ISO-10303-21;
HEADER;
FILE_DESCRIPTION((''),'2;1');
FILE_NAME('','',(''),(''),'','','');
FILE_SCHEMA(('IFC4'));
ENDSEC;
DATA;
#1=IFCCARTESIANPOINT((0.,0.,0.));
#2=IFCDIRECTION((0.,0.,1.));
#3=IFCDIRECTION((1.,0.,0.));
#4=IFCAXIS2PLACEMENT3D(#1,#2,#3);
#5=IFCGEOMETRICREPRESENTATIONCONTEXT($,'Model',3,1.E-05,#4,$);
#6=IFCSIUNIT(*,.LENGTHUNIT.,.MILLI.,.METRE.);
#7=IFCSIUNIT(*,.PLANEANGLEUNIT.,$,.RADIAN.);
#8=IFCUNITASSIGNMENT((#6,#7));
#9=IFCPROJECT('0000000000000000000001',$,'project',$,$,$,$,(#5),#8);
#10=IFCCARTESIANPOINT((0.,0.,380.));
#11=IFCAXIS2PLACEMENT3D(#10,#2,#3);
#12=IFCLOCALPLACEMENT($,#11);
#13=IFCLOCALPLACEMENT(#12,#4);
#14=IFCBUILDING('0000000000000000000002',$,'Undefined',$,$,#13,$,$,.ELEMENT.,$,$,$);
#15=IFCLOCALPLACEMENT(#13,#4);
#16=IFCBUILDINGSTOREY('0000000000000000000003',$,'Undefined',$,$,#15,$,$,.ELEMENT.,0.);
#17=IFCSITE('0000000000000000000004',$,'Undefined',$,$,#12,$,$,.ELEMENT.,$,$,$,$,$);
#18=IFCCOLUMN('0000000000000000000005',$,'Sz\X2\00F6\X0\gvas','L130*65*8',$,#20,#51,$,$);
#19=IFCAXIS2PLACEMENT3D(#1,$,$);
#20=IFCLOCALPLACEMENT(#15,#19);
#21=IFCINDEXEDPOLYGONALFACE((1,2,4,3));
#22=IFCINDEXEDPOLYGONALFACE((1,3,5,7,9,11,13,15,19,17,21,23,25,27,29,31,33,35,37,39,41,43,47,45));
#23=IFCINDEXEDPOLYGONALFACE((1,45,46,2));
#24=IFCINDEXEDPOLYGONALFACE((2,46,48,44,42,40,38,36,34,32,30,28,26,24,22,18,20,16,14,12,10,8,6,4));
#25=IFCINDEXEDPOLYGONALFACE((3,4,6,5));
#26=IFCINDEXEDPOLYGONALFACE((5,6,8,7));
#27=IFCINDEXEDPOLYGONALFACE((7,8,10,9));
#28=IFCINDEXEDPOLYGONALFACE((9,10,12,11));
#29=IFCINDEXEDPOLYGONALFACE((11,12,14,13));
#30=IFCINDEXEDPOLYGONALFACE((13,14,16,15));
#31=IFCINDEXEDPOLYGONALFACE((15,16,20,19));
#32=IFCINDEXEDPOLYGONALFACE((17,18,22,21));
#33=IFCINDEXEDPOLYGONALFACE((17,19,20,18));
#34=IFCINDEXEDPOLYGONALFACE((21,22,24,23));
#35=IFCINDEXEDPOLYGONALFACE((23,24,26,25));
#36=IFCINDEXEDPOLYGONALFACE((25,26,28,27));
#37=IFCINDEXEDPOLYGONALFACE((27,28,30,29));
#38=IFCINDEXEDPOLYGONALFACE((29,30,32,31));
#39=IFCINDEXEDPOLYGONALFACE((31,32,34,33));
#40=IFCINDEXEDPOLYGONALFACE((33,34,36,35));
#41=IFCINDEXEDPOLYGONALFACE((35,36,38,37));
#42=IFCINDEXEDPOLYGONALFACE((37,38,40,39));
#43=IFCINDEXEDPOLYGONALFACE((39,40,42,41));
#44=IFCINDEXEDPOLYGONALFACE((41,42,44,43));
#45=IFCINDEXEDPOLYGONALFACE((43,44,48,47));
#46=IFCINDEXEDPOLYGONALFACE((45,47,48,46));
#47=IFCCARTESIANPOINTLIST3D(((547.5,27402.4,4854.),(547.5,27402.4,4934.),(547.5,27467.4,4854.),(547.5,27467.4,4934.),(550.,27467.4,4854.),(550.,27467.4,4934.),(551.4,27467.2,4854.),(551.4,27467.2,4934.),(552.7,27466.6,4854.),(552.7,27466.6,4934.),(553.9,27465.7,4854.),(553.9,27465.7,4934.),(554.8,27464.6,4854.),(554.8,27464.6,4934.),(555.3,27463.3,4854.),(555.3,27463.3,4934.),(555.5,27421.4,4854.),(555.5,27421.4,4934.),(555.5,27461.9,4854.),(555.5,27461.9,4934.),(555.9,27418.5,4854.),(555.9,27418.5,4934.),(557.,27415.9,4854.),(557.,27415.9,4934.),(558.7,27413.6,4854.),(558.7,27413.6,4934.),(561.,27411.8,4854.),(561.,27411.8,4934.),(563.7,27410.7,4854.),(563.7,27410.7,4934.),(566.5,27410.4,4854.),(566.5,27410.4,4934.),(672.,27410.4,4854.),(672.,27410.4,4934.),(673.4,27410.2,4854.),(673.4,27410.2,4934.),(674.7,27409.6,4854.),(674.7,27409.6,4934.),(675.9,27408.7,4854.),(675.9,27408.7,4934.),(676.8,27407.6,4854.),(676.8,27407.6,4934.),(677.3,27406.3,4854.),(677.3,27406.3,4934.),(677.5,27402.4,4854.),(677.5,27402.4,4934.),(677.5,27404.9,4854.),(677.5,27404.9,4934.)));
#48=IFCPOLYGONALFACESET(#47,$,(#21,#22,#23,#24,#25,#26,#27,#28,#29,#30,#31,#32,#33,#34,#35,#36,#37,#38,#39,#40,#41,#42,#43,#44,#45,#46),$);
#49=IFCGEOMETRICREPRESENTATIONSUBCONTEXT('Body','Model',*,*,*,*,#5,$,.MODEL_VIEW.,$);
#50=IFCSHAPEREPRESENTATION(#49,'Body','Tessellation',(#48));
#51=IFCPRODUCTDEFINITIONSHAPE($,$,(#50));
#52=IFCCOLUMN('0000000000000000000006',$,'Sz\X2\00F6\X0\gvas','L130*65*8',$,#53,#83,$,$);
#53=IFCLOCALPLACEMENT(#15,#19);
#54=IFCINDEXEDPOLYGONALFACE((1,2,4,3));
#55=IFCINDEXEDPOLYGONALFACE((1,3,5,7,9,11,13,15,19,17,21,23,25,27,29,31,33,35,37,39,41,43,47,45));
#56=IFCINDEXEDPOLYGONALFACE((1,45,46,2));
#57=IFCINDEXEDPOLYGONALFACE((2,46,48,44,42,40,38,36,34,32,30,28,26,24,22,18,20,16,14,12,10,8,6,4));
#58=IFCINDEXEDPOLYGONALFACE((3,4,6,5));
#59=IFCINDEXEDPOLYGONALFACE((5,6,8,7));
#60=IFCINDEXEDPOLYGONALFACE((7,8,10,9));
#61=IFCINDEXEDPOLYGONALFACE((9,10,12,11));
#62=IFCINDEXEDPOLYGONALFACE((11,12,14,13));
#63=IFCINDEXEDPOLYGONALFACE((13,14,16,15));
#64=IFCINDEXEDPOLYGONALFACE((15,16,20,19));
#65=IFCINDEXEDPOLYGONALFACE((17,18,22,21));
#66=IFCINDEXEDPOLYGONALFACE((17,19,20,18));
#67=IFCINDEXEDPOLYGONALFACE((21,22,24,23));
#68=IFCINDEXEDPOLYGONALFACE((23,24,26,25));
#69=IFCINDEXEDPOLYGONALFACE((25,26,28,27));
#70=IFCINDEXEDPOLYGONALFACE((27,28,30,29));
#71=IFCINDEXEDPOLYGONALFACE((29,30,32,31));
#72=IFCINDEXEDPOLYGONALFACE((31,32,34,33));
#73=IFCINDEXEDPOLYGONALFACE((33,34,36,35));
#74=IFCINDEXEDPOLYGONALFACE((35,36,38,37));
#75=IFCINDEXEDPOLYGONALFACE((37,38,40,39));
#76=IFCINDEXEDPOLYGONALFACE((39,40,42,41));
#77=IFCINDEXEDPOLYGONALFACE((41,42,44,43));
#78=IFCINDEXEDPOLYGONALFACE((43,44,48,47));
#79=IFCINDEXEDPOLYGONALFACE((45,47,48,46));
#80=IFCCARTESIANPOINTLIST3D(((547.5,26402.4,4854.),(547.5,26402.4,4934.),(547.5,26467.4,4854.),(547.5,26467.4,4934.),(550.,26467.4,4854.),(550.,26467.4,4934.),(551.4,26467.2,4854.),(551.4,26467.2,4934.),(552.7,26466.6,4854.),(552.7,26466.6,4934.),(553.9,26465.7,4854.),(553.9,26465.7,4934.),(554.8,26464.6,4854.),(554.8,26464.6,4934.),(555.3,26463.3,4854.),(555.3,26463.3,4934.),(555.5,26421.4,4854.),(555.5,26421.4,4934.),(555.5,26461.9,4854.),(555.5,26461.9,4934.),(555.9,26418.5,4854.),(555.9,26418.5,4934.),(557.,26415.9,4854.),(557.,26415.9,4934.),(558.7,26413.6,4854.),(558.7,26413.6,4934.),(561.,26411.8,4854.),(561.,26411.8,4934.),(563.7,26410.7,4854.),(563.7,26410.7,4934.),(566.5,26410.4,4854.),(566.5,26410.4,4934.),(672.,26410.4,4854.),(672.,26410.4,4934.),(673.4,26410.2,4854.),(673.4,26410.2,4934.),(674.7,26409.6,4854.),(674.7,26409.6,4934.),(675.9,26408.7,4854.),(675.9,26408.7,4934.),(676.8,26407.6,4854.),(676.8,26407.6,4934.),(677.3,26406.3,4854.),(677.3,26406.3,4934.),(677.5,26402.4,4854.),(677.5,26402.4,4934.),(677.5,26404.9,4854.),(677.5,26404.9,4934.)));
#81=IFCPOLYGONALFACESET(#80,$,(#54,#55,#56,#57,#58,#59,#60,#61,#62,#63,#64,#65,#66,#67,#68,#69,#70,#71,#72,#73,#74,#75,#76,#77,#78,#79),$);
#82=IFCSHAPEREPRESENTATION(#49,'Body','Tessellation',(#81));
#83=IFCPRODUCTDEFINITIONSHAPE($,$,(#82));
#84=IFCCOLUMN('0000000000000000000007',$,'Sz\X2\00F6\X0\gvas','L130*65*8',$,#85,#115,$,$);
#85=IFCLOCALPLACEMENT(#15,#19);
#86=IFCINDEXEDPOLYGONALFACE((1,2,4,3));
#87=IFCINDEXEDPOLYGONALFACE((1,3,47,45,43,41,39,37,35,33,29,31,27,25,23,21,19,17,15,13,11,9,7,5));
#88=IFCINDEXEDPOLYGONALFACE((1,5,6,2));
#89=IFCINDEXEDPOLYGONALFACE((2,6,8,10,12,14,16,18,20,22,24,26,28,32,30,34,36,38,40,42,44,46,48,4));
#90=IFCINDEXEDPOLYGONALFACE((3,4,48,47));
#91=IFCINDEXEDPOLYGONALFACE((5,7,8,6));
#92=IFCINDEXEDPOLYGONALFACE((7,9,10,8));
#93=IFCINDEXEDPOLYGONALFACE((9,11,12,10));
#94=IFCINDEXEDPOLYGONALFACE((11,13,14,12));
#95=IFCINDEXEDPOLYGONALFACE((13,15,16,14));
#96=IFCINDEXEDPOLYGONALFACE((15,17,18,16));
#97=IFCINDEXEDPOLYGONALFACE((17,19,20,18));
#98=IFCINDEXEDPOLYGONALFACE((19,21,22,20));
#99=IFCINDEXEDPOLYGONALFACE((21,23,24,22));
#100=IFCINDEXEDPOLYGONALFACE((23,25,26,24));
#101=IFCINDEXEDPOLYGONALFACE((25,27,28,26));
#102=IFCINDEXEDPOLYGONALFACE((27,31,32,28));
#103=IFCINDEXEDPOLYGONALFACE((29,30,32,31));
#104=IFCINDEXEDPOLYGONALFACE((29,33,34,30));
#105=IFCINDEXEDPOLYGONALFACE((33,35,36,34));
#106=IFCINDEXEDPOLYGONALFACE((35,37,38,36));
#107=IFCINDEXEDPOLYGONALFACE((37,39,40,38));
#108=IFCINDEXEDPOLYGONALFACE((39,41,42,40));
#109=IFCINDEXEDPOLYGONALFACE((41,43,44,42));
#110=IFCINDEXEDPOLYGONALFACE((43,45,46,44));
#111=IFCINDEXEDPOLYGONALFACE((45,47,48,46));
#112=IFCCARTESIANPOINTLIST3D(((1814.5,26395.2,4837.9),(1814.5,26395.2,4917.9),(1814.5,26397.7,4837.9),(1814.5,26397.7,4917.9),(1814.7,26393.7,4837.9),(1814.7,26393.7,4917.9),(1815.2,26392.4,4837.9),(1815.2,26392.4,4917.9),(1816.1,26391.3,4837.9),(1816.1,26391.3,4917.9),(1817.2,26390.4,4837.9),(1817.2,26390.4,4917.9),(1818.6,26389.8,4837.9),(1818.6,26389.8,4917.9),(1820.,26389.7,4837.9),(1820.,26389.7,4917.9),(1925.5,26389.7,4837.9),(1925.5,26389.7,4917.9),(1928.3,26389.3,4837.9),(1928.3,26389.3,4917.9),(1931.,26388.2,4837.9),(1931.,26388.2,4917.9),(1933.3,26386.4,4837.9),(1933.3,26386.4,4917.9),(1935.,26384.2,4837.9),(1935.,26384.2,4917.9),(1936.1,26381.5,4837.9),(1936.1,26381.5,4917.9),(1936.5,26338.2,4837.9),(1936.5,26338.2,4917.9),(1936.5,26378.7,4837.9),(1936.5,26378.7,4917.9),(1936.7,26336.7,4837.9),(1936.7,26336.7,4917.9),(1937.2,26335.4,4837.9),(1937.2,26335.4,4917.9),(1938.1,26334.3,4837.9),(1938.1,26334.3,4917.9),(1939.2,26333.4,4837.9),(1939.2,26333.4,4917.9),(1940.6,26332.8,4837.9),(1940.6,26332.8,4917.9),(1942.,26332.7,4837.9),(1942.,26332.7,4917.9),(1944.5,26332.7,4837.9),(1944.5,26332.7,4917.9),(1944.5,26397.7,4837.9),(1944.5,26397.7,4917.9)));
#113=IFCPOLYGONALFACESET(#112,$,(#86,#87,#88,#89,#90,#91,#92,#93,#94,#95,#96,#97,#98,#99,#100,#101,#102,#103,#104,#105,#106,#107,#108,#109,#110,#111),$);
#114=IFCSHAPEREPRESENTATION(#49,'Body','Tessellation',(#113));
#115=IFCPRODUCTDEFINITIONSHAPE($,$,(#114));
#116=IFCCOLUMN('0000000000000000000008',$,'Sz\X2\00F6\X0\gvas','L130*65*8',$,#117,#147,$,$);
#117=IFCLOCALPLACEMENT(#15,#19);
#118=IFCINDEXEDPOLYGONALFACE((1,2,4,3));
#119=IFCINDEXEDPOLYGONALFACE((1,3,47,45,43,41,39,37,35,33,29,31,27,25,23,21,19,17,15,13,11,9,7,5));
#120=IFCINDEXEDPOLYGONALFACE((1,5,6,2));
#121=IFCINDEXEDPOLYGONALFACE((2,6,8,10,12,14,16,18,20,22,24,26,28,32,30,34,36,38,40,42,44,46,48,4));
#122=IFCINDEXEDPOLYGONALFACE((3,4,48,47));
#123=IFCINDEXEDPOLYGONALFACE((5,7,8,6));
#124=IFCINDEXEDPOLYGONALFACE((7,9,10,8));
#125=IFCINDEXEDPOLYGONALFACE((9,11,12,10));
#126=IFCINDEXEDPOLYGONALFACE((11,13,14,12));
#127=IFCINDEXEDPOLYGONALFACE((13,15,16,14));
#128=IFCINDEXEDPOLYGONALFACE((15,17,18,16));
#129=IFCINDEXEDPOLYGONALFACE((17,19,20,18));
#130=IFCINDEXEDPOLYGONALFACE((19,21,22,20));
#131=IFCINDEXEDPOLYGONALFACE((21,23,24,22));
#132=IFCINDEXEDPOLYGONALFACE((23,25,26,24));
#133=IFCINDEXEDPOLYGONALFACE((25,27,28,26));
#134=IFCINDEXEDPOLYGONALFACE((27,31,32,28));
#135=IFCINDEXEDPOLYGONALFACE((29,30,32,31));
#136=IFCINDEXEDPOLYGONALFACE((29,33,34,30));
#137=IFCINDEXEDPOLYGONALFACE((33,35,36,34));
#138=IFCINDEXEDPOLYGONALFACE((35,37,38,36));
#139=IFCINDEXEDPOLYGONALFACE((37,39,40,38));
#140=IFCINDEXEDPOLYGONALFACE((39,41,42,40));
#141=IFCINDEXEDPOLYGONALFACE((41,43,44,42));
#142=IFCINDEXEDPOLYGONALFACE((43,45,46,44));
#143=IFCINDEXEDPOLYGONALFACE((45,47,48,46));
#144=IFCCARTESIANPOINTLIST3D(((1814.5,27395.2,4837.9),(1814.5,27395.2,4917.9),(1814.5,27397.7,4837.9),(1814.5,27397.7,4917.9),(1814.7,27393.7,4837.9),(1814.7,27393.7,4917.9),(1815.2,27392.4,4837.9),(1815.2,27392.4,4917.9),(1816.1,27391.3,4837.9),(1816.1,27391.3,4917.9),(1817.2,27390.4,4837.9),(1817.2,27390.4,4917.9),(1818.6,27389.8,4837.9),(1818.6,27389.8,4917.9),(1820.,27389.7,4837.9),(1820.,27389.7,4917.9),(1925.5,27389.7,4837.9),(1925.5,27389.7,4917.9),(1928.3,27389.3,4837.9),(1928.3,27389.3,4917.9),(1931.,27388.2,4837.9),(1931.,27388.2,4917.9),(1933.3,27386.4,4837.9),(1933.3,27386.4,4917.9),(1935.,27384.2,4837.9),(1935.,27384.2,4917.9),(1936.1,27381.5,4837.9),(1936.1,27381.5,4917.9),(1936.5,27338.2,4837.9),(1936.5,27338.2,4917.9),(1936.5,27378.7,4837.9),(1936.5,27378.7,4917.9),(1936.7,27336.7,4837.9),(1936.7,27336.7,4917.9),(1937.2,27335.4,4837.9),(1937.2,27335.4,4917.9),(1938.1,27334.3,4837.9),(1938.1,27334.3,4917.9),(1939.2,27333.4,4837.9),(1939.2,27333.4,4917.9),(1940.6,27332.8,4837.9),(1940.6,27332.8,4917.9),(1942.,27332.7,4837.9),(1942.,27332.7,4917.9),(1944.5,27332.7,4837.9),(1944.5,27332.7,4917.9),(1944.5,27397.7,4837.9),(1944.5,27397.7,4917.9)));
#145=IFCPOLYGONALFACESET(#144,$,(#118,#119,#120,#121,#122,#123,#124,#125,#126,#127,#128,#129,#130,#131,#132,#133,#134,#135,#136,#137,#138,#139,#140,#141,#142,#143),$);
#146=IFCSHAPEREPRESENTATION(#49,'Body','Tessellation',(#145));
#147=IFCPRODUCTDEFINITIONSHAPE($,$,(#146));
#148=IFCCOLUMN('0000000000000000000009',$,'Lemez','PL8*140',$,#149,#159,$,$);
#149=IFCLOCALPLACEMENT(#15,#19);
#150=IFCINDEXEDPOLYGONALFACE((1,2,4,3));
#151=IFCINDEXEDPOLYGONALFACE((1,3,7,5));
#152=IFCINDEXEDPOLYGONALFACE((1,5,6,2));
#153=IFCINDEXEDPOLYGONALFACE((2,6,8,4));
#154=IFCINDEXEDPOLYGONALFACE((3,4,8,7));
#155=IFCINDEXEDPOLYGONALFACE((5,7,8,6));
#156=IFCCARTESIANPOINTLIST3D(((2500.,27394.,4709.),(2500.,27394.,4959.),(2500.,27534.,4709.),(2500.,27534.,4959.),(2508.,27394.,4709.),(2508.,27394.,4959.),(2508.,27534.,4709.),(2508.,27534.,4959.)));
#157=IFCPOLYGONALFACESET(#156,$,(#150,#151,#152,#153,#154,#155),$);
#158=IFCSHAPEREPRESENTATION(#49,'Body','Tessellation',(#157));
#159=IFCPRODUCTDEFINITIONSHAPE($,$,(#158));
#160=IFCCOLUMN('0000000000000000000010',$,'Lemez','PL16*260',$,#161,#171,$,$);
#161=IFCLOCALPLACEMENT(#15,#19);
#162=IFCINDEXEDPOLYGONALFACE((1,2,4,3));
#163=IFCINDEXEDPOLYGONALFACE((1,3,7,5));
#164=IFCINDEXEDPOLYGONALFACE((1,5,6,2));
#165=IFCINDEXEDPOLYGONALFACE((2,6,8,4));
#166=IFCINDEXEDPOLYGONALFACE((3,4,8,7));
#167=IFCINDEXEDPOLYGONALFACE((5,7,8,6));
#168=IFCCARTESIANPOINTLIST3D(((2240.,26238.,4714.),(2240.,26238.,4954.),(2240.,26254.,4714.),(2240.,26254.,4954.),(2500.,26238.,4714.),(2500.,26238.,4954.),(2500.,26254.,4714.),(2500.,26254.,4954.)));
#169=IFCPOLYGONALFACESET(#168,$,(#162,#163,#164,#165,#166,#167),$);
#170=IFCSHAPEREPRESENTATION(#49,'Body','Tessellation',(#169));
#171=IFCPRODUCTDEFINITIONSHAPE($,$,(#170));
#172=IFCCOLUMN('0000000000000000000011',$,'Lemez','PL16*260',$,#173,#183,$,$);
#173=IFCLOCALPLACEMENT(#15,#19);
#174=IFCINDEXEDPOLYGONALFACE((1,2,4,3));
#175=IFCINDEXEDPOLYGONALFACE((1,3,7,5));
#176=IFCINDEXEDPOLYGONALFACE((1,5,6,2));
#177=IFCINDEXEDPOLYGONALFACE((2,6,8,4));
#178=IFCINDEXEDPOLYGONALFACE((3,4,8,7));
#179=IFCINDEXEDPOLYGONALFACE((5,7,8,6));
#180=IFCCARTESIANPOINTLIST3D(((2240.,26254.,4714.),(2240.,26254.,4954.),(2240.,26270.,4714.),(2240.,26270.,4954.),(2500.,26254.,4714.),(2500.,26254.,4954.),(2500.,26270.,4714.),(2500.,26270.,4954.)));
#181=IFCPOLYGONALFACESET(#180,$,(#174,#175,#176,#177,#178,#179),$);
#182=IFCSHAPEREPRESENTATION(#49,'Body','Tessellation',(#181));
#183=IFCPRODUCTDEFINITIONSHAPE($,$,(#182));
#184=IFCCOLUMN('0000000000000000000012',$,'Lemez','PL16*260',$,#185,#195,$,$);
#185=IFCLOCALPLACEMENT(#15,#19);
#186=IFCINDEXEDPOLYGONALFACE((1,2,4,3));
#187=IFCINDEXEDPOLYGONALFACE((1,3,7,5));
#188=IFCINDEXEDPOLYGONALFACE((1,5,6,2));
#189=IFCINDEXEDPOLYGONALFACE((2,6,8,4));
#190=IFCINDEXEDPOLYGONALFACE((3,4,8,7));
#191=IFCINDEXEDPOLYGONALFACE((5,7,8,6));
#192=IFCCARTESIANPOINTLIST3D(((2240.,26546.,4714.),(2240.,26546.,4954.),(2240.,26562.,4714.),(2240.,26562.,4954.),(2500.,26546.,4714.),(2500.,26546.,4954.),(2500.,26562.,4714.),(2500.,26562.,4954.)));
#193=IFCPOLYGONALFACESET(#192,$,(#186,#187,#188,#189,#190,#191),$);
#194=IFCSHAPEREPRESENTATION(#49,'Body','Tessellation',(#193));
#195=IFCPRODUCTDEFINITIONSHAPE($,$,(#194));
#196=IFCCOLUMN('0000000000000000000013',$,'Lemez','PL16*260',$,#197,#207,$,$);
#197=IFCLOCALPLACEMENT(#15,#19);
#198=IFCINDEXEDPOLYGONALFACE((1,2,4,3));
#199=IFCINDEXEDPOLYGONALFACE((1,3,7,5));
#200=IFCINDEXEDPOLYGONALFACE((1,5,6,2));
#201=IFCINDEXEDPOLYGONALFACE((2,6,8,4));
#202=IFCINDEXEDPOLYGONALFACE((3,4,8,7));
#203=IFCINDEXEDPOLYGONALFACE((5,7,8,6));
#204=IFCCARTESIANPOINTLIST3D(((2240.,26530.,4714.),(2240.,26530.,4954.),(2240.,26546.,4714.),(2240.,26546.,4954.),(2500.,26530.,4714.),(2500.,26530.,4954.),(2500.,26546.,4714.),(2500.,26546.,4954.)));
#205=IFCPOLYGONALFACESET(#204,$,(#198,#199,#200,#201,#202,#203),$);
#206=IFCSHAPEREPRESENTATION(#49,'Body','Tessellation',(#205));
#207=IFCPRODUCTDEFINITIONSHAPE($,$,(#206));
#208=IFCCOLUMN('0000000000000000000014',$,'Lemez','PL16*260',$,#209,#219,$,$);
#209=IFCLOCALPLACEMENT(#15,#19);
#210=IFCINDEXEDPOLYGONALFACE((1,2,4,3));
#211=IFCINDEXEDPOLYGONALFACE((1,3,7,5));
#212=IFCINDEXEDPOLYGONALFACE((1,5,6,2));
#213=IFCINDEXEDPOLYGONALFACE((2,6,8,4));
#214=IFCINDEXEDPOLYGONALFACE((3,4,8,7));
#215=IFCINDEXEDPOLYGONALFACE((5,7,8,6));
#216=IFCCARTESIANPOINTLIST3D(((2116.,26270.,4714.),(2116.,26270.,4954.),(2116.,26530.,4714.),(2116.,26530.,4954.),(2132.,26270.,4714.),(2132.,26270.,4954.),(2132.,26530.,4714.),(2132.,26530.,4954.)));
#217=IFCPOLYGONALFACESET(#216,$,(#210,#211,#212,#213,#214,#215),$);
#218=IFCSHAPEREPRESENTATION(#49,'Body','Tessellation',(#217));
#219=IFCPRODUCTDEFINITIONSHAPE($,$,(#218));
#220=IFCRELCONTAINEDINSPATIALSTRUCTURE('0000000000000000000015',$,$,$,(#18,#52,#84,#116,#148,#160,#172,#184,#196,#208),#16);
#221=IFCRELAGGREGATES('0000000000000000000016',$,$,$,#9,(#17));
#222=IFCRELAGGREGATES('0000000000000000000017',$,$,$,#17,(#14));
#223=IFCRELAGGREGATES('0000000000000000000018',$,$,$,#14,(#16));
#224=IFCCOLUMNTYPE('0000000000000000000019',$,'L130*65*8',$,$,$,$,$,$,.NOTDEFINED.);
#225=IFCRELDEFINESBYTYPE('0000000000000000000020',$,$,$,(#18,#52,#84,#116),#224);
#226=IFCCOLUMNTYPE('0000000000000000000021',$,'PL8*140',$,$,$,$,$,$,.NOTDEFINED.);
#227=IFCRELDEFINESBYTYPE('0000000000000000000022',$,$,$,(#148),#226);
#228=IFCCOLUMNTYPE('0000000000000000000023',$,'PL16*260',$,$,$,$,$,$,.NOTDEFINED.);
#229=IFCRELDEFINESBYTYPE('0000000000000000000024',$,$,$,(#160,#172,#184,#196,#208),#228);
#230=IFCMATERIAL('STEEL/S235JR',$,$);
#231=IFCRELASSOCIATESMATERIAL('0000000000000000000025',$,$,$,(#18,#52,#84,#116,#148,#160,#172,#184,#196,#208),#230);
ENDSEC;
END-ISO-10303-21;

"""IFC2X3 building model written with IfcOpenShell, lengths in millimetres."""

from ifc_helpers import new_model, si_unit, frame, origin_with_axes, origin_2d_with_axis, place, context, subcontext, project, spatial, rectangle, l_section, extrude, material, type_object, element, save


model = new_model("IFC2X3")

# Units and contexts
model_context = context("Model", 3, precision=1e-05, world=origin_with_axes())
body_context = subcontext(model_context, "Body", "Model", "MODEL_VIEW")
ifc_project = project(units=[si_unit("LENGTHUNIT", "METRE", prefix="MILLI"), si_unit("PLANEANGLEUNIT", "RADIAN")], contexts=[model_context])

# Site, building, storey
site_placement = place(None, frame((0.0, 0.0, 380.0), z_axis=(0.0, 0.0, 1.0), x_axis=(1.0, 0.0, 0.0)))
site = spatial("IfcSite", under=ifc_project, at=site_placement, Name="Undefined", CompositionType="ELEMENT")
building_placement = place(site_placement, origin_with_axes())
building = spatial("IfcBuilding", under=site, at=building_placement, Name="Undefined", CompositionType="ELEMENT")
storey_placement = place(building_placement, origin_with_axes())
storey = spatial("IfcBuildingStorey", under=building, at=storey_placement, Name="Undefined", CompositionType="ELEMENT", Elevation=0.0)

# Columns
ifc_material = material(Name="STEEL/S235JR")
column_type_1 = type_object("IfcColumnType", Name="L130*65*8", PredefinedType="NOTDEFINED")
for number, where, z_axis, x_axis, name in (
    (1, (612.5, 27434.9, 4854.0), (0.0, 0.0, 1.0), (1.0, 0.0, 0.0), "Szögvas"),
    (2, (612.5, 26434.9, 4854.0), (0.0, 0.0, 1.0), (1.0, 0.0, 0.0), "Szögvas"),
    (3, (1879.5, 26365.2, 4837.9), (0.0, 0.0, 1.0), (-1.0, 0.0, 0.0), "Szögvas"),
    (4, (1879.5, 27365.2, 4837.9), (0.0, 0.0, 1.0), (-1.0, 0.0, 0.0), "Szögvas"),
):
    element("IfcColumn", number, at=place(storey_placement, frame(where, z_axis=z_axis, x_axis=x_axis)), inside=storey, type_object=column_type_1, material=ifc_material, Name=name, Description="L130*65*8", context=body_context, shape_type="SweptSolid", body=[
        extrude(l_section(Depth=130.0, Width=65.0, Thickness=8.0, FilletRadius=11.0, EdgeRadius=5.5, at=origin_2d_with_axis()), frame((0.0, 0.0, 80.0), z_axis=(0.0, 0.0, -1.0), x_axis=(0.0, 1.0, 0.0)), (0.0, 0.0, 1.0), 80.0),
    ])
column_type_2 = type_object("IfcColumnType", Name="PL8*140", PredefinedType="NOTDEFINED")
column_placement = place(storey_placement, frame((2504.0, 27464.0, 4709.0), z_axis=(0.0, 0.0, 1.0), x_axis=(0.0, -1.0, 0.0)))
element("IfcColumn", 5, at=column_placement, inside=storey, type_object=column_type_2, material=ifc_material, Name="Lemez", Description="PL8*140", context=body_context, shape_type="SweptSolid", body=[
    extrude(rectangle(XDim=8.0, YDim=140.0, at=origin_2d_with_axis()), frame((0.0, 0.0, 250.0), z_axis=(0.0, 0.0, -1.0), x_axis=(0.0, 1.0, 0.0)), (0.0, 0.0, 1.0), 250.0),
])
column_type_3 = type_object("IfcColumnType", Name="PL16*260", PredefinedType="NOTDEFINED")
for number, where, z_axis, x_axis, name in (
    (6, (2370.0, 26246.0, 4714.0), (0.0, 0.0, 1.0), (-1.0, 0.0, 0.0), "Lemez"),
    (7, (2370.0, 26262.0, 4714.0), (0.0, 0.0, 1.0), (-1.0, 0.0, 0.0), "Lemez"),
    (8, (2370.0, 26554.0, 4714.0), (0.0, 0.0, 1.0), (1.0, 0.0, 0.0), "Lemez"),
    (9, (2370.0, 26538.0, 4714.0), (0.0, 0.0, 1.0), (1.0, 0.0, 0.0), "Lemez"),
    (10, (2124.0, 26400.0, 4714.0), (0.0, 0.0, 1.0), (0.0, -1.0, 0.0), "Lemez"),
):
    element("IfcColumn", number, at=place(storey_placement, frame(where, z_axis=z_axis, x_axis=x_axis)), inside=storey, type_object=column_type_3, material=ifc_material, Name=name, Description="PL16*260", context=body_context, shape_type="SweptSolid", body=[
        extrude(rectangle(XDim=16.0, YDim=260.0, at=origin_2d_with_axis()), frame((0.0, 0.0, 240.0), z_axis=(0.0, 0.0, -1.0), x_axis=(0.0, 1.0, 0.0)), (0.0, 0.0, 1.0), 240.0),
    ])

save(model, "model.ifc")
